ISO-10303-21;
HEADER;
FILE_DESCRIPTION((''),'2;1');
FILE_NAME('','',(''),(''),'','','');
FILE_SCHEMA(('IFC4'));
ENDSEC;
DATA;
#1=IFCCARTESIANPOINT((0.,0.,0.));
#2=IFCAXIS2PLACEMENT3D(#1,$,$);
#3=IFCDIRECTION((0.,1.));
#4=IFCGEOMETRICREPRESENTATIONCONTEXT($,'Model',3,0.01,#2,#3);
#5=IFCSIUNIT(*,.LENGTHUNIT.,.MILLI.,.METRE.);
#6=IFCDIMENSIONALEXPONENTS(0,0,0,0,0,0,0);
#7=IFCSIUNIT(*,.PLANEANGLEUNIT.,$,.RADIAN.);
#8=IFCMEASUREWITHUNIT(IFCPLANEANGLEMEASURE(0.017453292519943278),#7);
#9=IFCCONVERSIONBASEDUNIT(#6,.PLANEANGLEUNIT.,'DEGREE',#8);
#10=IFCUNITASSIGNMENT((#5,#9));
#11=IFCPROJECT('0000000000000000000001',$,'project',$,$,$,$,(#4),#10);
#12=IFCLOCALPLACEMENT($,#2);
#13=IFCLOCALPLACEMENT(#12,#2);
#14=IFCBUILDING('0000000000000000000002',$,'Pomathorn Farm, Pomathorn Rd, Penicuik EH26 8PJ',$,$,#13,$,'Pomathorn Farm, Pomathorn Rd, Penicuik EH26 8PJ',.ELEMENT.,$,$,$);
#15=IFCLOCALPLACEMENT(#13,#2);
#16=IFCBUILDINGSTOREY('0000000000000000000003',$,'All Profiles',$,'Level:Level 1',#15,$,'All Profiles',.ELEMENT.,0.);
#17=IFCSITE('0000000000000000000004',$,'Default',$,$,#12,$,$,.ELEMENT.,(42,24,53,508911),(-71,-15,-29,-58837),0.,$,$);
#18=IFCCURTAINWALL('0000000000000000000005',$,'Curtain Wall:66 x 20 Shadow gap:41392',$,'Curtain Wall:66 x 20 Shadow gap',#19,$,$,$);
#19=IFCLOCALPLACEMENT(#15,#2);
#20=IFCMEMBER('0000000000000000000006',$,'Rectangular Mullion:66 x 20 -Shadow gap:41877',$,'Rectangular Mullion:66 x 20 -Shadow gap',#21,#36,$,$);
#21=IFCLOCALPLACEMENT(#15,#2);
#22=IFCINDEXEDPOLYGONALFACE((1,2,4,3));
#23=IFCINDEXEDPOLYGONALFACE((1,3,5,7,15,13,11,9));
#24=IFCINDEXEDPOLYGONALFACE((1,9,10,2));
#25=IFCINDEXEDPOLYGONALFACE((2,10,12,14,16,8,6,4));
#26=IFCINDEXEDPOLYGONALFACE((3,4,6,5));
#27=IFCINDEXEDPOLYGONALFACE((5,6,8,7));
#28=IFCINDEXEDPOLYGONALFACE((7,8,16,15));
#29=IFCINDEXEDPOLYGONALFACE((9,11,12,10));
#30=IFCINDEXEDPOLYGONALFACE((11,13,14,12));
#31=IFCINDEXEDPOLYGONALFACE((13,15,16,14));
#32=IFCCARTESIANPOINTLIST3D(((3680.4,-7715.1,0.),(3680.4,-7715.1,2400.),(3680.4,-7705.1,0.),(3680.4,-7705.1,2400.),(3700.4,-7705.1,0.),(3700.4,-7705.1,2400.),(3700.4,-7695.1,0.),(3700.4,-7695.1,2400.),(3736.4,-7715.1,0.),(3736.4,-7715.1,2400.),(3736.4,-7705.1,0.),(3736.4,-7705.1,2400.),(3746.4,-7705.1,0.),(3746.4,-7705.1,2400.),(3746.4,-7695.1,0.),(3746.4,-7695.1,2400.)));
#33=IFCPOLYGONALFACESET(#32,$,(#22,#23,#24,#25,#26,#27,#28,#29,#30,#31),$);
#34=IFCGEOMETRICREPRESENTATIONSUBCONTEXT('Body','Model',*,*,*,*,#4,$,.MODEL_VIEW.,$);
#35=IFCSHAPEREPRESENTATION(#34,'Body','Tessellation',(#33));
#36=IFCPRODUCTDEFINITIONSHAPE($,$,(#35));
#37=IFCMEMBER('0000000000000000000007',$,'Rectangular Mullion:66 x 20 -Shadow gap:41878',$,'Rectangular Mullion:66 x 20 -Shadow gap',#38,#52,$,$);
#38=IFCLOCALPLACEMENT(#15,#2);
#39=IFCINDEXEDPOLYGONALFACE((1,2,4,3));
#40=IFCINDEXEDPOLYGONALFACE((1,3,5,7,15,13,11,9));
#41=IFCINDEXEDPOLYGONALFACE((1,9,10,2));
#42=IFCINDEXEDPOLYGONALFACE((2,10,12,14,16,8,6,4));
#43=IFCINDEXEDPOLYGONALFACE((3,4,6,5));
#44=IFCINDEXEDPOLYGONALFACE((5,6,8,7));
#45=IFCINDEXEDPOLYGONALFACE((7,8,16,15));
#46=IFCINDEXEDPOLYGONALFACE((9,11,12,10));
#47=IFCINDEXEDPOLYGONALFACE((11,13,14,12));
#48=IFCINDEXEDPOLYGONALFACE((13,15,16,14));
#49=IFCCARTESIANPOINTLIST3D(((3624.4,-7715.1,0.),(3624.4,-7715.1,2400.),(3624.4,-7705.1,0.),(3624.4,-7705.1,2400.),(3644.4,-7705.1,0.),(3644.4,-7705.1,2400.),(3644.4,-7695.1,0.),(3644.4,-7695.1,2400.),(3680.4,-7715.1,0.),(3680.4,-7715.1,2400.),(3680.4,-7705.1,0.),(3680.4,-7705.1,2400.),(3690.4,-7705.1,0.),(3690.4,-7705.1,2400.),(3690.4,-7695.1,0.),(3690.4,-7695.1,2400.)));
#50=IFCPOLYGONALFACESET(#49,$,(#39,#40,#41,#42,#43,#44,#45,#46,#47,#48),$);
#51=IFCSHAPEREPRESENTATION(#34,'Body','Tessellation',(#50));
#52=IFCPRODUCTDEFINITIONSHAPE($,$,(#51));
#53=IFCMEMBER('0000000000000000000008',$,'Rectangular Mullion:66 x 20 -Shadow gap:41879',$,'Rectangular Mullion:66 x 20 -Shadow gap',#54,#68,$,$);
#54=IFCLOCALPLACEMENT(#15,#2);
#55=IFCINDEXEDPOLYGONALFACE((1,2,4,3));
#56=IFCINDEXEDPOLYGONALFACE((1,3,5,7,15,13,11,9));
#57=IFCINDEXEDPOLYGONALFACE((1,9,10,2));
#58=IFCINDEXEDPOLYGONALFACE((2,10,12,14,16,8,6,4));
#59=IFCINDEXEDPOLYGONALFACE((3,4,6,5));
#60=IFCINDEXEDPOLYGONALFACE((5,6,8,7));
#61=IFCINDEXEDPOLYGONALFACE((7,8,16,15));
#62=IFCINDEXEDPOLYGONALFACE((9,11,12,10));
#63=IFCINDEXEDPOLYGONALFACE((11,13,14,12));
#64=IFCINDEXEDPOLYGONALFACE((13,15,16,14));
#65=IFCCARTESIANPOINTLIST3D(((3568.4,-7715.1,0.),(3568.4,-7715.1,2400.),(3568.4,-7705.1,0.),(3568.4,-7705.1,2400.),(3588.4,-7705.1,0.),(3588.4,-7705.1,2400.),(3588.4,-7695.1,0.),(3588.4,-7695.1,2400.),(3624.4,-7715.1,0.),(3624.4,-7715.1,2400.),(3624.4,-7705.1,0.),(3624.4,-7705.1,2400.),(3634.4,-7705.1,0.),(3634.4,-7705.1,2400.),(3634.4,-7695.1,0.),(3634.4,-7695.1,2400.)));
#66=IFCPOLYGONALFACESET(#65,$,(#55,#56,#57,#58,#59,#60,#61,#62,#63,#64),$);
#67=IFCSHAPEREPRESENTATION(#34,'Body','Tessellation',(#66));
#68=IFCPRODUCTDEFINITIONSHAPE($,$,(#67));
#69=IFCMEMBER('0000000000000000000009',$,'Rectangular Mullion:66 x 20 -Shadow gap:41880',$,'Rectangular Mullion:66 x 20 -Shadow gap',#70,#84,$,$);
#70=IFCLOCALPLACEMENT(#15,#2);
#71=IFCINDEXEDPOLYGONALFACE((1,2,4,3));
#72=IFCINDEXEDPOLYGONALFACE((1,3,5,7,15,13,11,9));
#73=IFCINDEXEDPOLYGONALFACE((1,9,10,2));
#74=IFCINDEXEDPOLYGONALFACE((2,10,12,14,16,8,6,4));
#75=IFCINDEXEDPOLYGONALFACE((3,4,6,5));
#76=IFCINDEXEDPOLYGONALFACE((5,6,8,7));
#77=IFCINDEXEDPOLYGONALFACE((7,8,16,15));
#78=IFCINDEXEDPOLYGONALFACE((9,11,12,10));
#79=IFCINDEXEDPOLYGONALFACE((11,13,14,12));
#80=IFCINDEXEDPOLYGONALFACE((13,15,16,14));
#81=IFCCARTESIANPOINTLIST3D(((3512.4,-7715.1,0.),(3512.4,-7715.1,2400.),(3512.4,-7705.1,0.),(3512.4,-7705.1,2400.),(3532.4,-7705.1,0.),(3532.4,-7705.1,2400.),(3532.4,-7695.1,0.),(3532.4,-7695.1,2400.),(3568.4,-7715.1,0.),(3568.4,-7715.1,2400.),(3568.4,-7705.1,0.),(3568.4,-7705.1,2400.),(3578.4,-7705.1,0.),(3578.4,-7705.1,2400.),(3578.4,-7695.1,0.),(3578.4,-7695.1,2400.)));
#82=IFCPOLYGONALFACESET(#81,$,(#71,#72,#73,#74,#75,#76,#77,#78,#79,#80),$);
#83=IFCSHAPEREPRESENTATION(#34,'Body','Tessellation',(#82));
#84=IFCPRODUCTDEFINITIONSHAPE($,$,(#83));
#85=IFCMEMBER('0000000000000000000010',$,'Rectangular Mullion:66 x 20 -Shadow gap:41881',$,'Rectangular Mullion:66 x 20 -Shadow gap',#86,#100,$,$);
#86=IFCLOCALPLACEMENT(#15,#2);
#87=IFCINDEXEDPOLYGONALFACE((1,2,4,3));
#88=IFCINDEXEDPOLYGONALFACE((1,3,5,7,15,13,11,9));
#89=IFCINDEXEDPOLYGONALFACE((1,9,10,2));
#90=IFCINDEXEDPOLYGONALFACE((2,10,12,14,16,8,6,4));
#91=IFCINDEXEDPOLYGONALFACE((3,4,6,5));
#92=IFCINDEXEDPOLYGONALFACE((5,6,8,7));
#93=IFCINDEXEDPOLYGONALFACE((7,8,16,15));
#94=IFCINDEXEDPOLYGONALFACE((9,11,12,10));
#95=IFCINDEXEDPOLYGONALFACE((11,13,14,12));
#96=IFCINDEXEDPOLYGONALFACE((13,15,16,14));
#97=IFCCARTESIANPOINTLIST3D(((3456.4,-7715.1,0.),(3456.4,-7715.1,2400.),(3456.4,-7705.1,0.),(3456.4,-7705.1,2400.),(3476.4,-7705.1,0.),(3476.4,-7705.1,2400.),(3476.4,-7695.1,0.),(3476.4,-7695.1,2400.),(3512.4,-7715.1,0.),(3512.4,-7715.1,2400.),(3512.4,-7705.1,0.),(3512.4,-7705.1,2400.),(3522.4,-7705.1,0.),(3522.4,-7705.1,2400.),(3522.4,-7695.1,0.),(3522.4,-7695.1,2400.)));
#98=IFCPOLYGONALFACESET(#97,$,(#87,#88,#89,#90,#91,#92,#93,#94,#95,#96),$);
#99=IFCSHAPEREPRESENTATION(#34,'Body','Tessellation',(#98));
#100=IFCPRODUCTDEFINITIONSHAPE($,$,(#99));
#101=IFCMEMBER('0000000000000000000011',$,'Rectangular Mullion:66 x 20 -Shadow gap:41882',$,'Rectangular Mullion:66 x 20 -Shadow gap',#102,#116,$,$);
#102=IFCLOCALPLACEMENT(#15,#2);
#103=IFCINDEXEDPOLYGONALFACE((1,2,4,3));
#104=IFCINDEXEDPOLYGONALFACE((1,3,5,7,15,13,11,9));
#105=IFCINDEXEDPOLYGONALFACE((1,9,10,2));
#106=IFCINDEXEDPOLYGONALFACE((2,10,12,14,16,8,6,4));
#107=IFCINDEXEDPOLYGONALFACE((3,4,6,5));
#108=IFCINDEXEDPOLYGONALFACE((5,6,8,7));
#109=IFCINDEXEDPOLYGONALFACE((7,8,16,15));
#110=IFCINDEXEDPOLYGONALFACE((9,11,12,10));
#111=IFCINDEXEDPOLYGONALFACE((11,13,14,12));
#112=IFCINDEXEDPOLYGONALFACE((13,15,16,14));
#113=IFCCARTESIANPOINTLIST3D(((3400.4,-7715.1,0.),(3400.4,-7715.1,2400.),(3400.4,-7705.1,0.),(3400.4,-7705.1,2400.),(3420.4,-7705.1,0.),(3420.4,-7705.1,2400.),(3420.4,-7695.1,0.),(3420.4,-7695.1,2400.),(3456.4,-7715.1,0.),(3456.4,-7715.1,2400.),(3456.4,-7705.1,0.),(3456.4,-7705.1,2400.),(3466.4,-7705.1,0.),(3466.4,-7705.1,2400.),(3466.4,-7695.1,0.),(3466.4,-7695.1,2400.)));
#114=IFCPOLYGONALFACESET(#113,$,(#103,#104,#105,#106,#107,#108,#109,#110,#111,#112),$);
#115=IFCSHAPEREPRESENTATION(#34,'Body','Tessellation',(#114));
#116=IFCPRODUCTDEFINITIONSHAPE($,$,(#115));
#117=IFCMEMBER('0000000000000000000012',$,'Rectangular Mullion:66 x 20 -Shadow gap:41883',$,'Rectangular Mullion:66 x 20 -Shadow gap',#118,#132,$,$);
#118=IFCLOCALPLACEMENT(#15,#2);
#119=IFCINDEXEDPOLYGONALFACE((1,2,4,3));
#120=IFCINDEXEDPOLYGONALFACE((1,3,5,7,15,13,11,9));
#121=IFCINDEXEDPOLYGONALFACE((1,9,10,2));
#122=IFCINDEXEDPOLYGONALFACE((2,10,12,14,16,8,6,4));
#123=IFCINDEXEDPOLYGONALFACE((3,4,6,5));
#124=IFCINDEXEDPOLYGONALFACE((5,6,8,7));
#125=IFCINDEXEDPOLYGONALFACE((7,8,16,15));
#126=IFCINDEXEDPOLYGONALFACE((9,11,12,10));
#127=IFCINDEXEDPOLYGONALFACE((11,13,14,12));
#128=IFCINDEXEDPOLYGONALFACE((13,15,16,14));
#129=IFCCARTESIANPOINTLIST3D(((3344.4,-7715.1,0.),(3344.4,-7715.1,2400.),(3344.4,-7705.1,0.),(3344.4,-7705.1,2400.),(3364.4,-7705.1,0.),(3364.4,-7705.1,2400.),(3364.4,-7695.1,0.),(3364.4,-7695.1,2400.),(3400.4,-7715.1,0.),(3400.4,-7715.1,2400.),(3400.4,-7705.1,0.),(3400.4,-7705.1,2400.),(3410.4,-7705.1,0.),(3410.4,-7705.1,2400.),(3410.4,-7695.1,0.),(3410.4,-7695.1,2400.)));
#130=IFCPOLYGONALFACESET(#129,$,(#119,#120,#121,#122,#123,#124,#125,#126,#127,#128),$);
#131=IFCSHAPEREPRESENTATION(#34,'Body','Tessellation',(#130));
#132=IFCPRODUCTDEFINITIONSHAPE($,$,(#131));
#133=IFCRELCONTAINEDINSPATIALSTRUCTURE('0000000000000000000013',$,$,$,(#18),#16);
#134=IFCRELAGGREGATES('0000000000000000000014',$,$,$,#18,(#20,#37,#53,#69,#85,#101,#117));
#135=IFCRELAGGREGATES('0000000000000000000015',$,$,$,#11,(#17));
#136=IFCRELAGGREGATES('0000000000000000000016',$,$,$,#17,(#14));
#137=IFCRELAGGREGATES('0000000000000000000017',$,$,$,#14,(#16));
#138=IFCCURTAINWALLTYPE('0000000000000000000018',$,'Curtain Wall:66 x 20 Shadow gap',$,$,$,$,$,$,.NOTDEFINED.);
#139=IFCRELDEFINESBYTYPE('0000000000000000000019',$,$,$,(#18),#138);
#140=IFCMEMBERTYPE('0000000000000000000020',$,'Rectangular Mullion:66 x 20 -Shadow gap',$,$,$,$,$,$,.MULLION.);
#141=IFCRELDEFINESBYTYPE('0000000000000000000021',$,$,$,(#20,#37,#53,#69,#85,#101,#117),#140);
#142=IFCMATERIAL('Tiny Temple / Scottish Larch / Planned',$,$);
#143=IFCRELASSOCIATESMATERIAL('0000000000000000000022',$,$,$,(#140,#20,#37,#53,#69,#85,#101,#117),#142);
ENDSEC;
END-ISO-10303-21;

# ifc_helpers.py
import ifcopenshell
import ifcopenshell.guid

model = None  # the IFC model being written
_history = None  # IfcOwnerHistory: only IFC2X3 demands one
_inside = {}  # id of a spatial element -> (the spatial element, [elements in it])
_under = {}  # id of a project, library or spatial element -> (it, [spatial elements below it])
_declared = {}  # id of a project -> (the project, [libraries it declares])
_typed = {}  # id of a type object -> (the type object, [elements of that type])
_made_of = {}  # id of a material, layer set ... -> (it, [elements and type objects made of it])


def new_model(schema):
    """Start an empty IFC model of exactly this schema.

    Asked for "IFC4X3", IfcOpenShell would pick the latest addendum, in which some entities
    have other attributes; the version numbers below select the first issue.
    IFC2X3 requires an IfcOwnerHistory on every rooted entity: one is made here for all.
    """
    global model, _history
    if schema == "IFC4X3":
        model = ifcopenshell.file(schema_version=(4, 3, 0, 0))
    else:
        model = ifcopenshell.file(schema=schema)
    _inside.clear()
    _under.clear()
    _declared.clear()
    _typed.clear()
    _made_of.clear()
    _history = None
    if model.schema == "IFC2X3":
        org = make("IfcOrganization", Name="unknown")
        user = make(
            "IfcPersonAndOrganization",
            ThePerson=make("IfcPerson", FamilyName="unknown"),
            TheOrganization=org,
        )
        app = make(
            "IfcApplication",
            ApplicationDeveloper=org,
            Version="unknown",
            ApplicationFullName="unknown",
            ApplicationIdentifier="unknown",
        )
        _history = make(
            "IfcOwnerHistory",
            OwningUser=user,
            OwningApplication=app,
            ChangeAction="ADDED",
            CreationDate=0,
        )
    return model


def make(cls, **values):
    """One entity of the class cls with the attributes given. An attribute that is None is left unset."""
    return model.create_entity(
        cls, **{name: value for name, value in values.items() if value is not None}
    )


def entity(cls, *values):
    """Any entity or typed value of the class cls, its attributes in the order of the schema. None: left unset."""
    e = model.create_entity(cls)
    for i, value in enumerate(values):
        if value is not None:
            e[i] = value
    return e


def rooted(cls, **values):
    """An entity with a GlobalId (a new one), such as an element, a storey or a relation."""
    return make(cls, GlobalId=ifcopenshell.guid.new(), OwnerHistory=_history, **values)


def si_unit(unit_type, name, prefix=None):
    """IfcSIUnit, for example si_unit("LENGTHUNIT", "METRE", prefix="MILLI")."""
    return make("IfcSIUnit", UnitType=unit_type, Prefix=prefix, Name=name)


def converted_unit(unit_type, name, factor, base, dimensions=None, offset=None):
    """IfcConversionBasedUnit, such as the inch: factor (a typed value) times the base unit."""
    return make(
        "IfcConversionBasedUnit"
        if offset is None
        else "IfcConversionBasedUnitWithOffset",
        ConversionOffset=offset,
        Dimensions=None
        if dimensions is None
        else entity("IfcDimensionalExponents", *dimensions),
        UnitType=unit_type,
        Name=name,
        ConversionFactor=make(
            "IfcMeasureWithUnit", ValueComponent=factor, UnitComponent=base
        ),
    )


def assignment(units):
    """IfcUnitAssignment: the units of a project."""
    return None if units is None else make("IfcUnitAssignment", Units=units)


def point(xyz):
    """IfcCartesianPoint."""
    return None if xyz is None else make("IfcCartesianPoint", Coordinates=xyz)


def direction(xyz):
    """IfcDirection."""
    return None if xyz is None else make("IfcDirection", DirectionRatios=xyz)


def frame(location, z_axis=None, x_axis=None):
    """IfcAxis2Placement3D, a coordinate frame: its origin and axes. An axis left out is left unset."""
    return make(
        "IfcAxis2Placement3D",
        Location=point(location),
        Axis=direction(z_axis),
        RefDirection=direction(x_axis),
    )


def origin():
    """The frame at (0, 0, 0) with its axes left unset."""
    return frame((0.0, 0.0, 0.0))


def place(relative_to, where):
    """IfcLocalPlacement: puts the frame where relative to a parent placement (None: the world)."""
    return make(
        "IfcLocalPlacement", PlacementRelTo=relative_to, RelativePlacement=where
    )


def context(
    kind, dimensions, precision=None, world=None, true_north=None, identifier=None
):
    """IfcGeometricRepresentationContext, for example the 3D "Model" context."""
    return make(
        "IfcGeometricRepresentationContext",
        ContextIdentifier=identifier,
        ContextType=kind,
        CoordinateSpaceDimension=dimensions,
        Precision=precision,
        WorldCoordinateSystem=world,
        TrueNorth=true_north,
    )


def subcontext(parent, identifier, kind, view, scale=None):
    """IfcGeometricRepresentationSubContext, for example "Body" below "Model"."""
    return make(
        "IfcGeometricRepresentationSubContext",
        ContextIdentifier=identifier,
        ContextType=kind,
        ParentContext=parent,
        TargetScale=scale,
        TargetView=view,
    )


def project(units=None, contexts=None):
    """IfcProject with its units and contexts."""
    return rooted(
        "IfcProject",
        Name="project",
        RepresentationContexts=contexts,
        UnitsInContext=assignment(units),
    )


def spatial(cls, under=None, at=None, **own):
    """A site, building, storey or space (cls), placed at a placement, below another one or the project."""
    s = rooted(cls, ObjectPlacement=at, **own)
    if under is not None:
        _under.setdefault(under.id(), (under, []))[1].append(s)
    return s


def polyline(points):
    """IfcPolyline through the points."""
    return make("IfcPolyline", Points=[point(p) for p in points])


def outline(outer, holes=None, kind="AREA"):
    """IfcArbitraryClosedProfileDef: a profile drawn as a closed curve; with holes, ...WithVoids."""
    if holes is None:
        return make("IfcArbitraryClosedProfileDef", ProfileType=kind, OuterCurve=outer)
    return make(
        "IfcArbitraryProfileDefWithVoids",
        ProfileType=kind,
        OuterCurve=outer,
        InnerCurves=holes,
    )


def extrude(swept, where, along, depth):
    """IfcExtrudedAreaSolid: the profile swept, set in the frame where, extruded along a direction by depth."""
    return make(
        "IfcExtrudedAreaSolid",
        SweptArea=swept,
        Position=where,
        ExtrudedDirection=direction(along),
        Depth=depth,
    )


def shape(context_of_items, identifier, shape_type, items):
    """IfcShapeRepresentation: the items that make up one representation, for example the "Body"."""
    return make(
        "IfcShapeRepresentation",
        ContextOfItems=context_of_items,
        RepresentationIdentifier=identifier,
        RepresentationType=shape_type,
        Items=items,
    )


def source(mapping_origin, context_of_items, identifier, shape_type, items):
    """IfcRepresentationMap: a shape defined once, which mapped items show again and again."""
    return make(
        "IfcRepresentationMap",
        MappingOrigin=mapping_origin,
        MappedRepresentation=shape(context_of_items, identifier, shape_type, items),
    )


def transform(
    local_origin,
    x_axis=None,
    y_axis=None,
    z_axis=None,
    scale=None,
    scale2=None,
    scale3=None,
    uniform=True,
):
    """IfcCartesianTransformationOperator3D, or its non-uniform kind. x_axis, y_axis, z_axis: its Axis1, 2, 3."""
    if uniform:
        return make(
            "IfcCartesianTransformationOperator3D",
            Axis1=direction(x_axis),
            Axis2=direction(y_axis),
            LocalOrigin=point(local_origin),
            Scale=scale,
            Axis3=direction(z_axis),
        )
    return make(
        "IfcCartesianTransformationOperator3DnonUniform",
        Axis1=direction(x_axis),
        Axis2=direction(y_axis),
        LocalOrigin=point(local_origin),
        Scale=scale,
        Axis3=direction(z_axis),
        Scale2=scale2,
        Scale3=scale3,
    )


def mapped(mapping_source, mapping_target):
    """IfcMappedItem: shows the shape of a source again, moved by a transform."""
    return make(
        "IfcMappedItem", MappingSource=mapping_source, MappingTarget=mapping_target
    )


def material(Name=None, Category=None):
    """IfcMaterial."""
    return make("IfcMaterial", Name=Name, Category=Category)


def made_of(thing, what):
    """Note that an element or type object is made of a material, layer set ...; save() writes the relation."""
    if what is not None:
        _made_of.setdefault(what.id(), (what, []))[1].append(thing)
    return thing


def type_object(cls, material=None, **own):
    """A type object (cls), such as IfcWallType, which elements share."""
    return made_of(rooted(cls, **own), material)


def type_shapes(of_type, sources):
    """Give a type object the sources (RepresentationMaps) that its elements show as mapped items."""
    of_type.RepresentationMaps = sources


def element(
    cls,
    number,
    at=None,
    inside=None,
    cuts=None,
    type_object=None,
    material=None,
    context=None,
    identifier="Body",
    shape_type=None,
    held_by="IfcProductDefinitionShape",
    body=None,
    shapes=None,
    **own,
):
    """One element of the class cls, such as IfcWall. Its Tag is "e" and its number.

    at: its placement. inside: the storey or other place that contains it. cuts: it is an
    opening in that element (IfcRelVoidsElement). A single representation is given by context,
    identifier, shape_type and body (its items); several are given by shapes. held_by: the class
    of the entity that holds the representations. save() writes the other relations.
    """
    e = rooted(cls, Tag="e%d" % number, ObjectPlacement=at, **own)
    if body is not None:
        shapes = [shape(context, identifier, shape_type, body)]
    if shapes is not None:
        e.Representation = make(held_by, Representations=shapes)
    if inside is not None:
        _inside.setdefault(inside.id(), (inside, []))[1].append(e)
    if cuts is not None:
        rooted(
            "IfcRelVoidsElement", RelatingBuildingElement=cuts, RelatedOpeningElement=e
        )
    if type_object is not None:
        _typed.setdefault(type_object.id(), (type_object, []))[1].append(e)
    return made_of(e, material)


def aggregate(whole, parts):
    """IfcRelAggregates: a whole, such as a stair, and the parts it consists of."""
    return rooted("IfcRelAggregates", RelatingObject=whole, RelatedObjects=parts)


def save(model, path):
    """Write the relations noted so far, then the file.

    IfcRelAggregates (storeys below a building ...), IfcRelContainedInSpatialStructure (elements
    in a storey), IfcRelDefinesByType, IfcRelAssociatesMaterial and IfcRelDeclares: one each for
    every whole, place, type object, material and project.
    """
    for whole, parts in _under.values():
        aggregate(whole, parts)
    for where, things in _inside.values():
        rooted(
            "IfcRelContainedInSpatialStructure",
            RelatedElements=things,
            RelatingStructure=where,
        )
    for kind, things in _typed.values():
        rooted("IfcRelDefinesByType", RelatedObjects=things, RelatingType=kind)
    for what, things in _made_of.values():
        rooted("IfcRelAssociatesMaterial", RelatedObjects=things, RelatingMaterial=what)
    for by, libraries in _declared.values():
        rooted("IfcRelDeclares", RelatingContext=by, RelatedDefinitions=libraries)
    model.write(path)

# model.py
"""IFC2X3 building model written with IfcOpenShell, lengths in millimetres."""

from ifc_helpers import new_model, entity, si_unit, converted_unit, direction, frame, origin, place, context, subcontext, project, spatial, polyline, outline, extrude, source, transform, mapped, material, type_object, type_shapes, element, aggregate, save


model = new_model("IFC2X3")

# Units and contexts
model_context = context("Model", 3, precision=0.01, world=origin(), true_north=direction((0.0, 1.0)))
body_context = subcontext(model_context, "Body", "Model", "MODEL_VIEW")
ifc_project = project(units=[si_unit("LENGTHUNIT", "METRE", prefix="MILLI"), converted_unit("PLANEANGLEUNIT", "DEGREE", entity("IfcPlaneAngleMeasure", 0.017453292519943278), si_unit("PLANEANGLEUNIT", "RADIAN"), dimensions=[0, 0, 0, 0, 0, 0, 0])], contexts=[model_context])

# Site, building, storey
site_placement = place(None, origin())
site = spatial("IfcSite", under=ifc_project, at=site_placement, Name="Default", CompositionType="ELEMENT", RefLatitude=(42, 24, 53, 508911), RefLongitude=(-71, -15, -29, -58837), RefElevation=0.0)
building_placement = place(site_placement, origin())
building = spatial("IfcBuilding", under=site, at=building_placement, Name="Pomathorn Farm, Pomathorn Rd, Penicuik EH26 8PJ", LongName="Pomathorn Farm, Pomathorn Rd, Penicuik EH26 8PJ", CompositionType="ELEMENT")
storey_placement = place(building_placement, origin())
storey = spatial("IfcBuildingStorey", under=building, at=storey_placement, Name="All Profiles", ObjectType="Level:Level 1", LongName="All Profiles", CompositionType="ELEMENT", Elevation=0.0)

# Curtain wall, members
ifc_material = material(Name="Tiny Temple / Scottish Larch / Planned")
curtain_wall_type_1 = type_object("IfcCurtainWallType", Name="Curtain Wall:66 x 20 Shadow gap", PredefinedType="NOTDEFINED")
curtain_wall_1_placement = place(storey_placement, origin())
curtain_wall_1 = element("IfcCurtainWall", 1, at=curtain_wall_1_placement, inside=storey, type_object=curtain_wall_type_1, Name="Curtain Wall:66 x 20 Shadow gap:41392", ObjectType="Curtain Wall:66 x 20 Shadow gap")
member_type_1 = type_object("IfcMemberType", Name="Rectangular Mullion:66 x 20 -Shadow gap", PredefinedType="MULLION", material=ifc_material)
shared_shape_1 = source(origin(), body_context, "Body", "SweptSolid", [
    extrude(outline(polyline([(-35.5, 0.0), (-35.5, -10.0), (20.5, -10.0), (20.5, 0.0), (30.5, 0.0), (30.5, 10.0), (-15.5, 10.0), (-15.5, 0.0), (-35.5, 0.0)])), frame((-30.5, -10.0, -2400.0), z_axis=(0.0, 0.0, -1.0), x_axis=(1.0, 0.0, 0.0)), (0.0, 0.0, -1.0), 2400.0),
])
type_shapes(member_type_1, [shared_shape_1])
member_1_placement = place(curtain_wall_1_placement, frame((3746.4, -7715.1, 0.0), z_axis=(0.0, 0.0, -1.0), x_axis=(1.0, 0.0, 0.0)))
member_1 = element("IfcMember", 2, at=member_1_placement, type_object=member_type_1, material=ifc_material, Name="Rectangular Mullion:66 x 20 -Shadow gap:41877", ObjectType="Rectangular Mullion:66 x 20 -Shadow gap", context=body_context, shape_type="MappedRepresentation", body=[
    mapped(shared_shape_1, transform((0.0, 0.0, 0.0), scale=1.0)),
])
member_2_placement = place(curtain_wall_1_placement, frame((3690.4, -7715.1, 0.0), z_axis=(0.0, 0.0, -1.0), x_axis=(1.0, 0.0, 0.0)))
member_2 = element("IfcMember", 3, at=member_2_placement, type_object=member_type_1, material=ifc_material, Name="Rectangular Mullion:66 x 20 -Shadow gap:41878", ObjectType="Rectangular Mullion:66 x 20 -Shadow gap", context=body_context, shape_type="MappedRepresentation", body=[
    mapped(shared_shape_1, transform((0.0, 0.0, 0.0), scale=1.0)),
])
member_3_placement = place(curtain_wall_1_placement, frame((3634.4, -7715.1, 0.0), z_axis=(0.0, 0.0, -1.0), x_axis=(1.0, 0.0, 0.0)))
member_3 = element("IfcMember", 4, at=member_3_placement, type_object=member_type_1, material=ifc_material, Name="Rectangular Mullion:66 x 20 -Shadow gap:41879", ObjectType="Rectangular Mullion:66 x 20 -Shadow gap", context=body_context, shape_type="MappedRepresentation", body=[
    mapped(shared_shape_1, transform((0.0, 0.0, 0.0), scale=1.0)),
])
member_4_placement = place(curtain_wall_1_placement, frame((3578.4, -7715.1, 0.0), z_axis=(0.0, 0.0, -1.0), x_axis=(1.0, 0.0, 0.0)))
member_4 = element("IfcMember", 5, at=member_4_placement, type_object=member_type_1, material=ifc_material, Name="Rectangular Mullion:66 x 20 -Shadow gap:41880", ObjectType="Rectangular Mullion:66 x 20 -Shadow gap", context=body_context, shape_type="MappedRepresentation", body=[
    mapped(shared_shape_1, transform((0.0, 0.0, 0.0), scale=1.0)),
])
member_5_placement = place(curtain_wall_1_placement, frame((3522.4, -7715.1, 0.0), z_axis=(0.0, 0.0, -1.0), x_axis=(1.0, 0.0, 0.0)))
member_5 = element("IfcMember", 6, at=member_5_placement, type_object=member_type_1, material=ifc_material, Name="Rectangular Mullion:66 x 20 -Shadow gap:41881", ObjectType="Rectangular Mullion:66 x 20 -Shadow gap", context=body_context, shape_type="MappedRepresentation", body=[
    mapped(shared_shape_1, transform((0.0, 0.0, 0.0), scale=1.0)),
])
member_6_placement = place(curtain_wall_1_placement, frame((3466.4, -7715.1, 0.0), z_axis=(0.0, 0.0, -1.0), x_axis=(1.0, 0.0, 0.0)))
member_6 = element("IfcMember", 7, at=member_6_placement, type_object=member_type_1, material=ifc_material, Name="Rectangular Mullion:66 x 20 -Shadow gap:41882", ObjectType="Rectangular Mullion:66 x 20 -Shadow gap", context=body_context, shape_type="MappedRepresentation", body=[
    mapped(shared_shape_1, transform((0.0, 0.0, 0.0), scale=1.0)),
])
member_7_placement = place(curtain_wall_1_placement, frame((3410.4, -7715.1, 0.0), z_axis=(0.0, 0.0, -1.0), x_axis=(1.0, 0.0, 0.0)))
member_7 = element("IfcMember", 8, at=member_7_placement, type_object=member_type_1, material=ifc_material, Name="Rectangular Mullion:66 x 20 -Shadow gap:41883", ObjectType="Rectangular Mullion:66 x 20 -Shadow gap", context=body_context, shape_type="MappedRepresentation", body=[
    mapped(shared_shape_1, transform((0.0, 0.0, 0.0), scale=1.0)),
])
aggregate(curtain_wall_1, [member_1, member_2, member_3, member_4, member_5, member_6, member_7])

save(model, "model.ifc")
